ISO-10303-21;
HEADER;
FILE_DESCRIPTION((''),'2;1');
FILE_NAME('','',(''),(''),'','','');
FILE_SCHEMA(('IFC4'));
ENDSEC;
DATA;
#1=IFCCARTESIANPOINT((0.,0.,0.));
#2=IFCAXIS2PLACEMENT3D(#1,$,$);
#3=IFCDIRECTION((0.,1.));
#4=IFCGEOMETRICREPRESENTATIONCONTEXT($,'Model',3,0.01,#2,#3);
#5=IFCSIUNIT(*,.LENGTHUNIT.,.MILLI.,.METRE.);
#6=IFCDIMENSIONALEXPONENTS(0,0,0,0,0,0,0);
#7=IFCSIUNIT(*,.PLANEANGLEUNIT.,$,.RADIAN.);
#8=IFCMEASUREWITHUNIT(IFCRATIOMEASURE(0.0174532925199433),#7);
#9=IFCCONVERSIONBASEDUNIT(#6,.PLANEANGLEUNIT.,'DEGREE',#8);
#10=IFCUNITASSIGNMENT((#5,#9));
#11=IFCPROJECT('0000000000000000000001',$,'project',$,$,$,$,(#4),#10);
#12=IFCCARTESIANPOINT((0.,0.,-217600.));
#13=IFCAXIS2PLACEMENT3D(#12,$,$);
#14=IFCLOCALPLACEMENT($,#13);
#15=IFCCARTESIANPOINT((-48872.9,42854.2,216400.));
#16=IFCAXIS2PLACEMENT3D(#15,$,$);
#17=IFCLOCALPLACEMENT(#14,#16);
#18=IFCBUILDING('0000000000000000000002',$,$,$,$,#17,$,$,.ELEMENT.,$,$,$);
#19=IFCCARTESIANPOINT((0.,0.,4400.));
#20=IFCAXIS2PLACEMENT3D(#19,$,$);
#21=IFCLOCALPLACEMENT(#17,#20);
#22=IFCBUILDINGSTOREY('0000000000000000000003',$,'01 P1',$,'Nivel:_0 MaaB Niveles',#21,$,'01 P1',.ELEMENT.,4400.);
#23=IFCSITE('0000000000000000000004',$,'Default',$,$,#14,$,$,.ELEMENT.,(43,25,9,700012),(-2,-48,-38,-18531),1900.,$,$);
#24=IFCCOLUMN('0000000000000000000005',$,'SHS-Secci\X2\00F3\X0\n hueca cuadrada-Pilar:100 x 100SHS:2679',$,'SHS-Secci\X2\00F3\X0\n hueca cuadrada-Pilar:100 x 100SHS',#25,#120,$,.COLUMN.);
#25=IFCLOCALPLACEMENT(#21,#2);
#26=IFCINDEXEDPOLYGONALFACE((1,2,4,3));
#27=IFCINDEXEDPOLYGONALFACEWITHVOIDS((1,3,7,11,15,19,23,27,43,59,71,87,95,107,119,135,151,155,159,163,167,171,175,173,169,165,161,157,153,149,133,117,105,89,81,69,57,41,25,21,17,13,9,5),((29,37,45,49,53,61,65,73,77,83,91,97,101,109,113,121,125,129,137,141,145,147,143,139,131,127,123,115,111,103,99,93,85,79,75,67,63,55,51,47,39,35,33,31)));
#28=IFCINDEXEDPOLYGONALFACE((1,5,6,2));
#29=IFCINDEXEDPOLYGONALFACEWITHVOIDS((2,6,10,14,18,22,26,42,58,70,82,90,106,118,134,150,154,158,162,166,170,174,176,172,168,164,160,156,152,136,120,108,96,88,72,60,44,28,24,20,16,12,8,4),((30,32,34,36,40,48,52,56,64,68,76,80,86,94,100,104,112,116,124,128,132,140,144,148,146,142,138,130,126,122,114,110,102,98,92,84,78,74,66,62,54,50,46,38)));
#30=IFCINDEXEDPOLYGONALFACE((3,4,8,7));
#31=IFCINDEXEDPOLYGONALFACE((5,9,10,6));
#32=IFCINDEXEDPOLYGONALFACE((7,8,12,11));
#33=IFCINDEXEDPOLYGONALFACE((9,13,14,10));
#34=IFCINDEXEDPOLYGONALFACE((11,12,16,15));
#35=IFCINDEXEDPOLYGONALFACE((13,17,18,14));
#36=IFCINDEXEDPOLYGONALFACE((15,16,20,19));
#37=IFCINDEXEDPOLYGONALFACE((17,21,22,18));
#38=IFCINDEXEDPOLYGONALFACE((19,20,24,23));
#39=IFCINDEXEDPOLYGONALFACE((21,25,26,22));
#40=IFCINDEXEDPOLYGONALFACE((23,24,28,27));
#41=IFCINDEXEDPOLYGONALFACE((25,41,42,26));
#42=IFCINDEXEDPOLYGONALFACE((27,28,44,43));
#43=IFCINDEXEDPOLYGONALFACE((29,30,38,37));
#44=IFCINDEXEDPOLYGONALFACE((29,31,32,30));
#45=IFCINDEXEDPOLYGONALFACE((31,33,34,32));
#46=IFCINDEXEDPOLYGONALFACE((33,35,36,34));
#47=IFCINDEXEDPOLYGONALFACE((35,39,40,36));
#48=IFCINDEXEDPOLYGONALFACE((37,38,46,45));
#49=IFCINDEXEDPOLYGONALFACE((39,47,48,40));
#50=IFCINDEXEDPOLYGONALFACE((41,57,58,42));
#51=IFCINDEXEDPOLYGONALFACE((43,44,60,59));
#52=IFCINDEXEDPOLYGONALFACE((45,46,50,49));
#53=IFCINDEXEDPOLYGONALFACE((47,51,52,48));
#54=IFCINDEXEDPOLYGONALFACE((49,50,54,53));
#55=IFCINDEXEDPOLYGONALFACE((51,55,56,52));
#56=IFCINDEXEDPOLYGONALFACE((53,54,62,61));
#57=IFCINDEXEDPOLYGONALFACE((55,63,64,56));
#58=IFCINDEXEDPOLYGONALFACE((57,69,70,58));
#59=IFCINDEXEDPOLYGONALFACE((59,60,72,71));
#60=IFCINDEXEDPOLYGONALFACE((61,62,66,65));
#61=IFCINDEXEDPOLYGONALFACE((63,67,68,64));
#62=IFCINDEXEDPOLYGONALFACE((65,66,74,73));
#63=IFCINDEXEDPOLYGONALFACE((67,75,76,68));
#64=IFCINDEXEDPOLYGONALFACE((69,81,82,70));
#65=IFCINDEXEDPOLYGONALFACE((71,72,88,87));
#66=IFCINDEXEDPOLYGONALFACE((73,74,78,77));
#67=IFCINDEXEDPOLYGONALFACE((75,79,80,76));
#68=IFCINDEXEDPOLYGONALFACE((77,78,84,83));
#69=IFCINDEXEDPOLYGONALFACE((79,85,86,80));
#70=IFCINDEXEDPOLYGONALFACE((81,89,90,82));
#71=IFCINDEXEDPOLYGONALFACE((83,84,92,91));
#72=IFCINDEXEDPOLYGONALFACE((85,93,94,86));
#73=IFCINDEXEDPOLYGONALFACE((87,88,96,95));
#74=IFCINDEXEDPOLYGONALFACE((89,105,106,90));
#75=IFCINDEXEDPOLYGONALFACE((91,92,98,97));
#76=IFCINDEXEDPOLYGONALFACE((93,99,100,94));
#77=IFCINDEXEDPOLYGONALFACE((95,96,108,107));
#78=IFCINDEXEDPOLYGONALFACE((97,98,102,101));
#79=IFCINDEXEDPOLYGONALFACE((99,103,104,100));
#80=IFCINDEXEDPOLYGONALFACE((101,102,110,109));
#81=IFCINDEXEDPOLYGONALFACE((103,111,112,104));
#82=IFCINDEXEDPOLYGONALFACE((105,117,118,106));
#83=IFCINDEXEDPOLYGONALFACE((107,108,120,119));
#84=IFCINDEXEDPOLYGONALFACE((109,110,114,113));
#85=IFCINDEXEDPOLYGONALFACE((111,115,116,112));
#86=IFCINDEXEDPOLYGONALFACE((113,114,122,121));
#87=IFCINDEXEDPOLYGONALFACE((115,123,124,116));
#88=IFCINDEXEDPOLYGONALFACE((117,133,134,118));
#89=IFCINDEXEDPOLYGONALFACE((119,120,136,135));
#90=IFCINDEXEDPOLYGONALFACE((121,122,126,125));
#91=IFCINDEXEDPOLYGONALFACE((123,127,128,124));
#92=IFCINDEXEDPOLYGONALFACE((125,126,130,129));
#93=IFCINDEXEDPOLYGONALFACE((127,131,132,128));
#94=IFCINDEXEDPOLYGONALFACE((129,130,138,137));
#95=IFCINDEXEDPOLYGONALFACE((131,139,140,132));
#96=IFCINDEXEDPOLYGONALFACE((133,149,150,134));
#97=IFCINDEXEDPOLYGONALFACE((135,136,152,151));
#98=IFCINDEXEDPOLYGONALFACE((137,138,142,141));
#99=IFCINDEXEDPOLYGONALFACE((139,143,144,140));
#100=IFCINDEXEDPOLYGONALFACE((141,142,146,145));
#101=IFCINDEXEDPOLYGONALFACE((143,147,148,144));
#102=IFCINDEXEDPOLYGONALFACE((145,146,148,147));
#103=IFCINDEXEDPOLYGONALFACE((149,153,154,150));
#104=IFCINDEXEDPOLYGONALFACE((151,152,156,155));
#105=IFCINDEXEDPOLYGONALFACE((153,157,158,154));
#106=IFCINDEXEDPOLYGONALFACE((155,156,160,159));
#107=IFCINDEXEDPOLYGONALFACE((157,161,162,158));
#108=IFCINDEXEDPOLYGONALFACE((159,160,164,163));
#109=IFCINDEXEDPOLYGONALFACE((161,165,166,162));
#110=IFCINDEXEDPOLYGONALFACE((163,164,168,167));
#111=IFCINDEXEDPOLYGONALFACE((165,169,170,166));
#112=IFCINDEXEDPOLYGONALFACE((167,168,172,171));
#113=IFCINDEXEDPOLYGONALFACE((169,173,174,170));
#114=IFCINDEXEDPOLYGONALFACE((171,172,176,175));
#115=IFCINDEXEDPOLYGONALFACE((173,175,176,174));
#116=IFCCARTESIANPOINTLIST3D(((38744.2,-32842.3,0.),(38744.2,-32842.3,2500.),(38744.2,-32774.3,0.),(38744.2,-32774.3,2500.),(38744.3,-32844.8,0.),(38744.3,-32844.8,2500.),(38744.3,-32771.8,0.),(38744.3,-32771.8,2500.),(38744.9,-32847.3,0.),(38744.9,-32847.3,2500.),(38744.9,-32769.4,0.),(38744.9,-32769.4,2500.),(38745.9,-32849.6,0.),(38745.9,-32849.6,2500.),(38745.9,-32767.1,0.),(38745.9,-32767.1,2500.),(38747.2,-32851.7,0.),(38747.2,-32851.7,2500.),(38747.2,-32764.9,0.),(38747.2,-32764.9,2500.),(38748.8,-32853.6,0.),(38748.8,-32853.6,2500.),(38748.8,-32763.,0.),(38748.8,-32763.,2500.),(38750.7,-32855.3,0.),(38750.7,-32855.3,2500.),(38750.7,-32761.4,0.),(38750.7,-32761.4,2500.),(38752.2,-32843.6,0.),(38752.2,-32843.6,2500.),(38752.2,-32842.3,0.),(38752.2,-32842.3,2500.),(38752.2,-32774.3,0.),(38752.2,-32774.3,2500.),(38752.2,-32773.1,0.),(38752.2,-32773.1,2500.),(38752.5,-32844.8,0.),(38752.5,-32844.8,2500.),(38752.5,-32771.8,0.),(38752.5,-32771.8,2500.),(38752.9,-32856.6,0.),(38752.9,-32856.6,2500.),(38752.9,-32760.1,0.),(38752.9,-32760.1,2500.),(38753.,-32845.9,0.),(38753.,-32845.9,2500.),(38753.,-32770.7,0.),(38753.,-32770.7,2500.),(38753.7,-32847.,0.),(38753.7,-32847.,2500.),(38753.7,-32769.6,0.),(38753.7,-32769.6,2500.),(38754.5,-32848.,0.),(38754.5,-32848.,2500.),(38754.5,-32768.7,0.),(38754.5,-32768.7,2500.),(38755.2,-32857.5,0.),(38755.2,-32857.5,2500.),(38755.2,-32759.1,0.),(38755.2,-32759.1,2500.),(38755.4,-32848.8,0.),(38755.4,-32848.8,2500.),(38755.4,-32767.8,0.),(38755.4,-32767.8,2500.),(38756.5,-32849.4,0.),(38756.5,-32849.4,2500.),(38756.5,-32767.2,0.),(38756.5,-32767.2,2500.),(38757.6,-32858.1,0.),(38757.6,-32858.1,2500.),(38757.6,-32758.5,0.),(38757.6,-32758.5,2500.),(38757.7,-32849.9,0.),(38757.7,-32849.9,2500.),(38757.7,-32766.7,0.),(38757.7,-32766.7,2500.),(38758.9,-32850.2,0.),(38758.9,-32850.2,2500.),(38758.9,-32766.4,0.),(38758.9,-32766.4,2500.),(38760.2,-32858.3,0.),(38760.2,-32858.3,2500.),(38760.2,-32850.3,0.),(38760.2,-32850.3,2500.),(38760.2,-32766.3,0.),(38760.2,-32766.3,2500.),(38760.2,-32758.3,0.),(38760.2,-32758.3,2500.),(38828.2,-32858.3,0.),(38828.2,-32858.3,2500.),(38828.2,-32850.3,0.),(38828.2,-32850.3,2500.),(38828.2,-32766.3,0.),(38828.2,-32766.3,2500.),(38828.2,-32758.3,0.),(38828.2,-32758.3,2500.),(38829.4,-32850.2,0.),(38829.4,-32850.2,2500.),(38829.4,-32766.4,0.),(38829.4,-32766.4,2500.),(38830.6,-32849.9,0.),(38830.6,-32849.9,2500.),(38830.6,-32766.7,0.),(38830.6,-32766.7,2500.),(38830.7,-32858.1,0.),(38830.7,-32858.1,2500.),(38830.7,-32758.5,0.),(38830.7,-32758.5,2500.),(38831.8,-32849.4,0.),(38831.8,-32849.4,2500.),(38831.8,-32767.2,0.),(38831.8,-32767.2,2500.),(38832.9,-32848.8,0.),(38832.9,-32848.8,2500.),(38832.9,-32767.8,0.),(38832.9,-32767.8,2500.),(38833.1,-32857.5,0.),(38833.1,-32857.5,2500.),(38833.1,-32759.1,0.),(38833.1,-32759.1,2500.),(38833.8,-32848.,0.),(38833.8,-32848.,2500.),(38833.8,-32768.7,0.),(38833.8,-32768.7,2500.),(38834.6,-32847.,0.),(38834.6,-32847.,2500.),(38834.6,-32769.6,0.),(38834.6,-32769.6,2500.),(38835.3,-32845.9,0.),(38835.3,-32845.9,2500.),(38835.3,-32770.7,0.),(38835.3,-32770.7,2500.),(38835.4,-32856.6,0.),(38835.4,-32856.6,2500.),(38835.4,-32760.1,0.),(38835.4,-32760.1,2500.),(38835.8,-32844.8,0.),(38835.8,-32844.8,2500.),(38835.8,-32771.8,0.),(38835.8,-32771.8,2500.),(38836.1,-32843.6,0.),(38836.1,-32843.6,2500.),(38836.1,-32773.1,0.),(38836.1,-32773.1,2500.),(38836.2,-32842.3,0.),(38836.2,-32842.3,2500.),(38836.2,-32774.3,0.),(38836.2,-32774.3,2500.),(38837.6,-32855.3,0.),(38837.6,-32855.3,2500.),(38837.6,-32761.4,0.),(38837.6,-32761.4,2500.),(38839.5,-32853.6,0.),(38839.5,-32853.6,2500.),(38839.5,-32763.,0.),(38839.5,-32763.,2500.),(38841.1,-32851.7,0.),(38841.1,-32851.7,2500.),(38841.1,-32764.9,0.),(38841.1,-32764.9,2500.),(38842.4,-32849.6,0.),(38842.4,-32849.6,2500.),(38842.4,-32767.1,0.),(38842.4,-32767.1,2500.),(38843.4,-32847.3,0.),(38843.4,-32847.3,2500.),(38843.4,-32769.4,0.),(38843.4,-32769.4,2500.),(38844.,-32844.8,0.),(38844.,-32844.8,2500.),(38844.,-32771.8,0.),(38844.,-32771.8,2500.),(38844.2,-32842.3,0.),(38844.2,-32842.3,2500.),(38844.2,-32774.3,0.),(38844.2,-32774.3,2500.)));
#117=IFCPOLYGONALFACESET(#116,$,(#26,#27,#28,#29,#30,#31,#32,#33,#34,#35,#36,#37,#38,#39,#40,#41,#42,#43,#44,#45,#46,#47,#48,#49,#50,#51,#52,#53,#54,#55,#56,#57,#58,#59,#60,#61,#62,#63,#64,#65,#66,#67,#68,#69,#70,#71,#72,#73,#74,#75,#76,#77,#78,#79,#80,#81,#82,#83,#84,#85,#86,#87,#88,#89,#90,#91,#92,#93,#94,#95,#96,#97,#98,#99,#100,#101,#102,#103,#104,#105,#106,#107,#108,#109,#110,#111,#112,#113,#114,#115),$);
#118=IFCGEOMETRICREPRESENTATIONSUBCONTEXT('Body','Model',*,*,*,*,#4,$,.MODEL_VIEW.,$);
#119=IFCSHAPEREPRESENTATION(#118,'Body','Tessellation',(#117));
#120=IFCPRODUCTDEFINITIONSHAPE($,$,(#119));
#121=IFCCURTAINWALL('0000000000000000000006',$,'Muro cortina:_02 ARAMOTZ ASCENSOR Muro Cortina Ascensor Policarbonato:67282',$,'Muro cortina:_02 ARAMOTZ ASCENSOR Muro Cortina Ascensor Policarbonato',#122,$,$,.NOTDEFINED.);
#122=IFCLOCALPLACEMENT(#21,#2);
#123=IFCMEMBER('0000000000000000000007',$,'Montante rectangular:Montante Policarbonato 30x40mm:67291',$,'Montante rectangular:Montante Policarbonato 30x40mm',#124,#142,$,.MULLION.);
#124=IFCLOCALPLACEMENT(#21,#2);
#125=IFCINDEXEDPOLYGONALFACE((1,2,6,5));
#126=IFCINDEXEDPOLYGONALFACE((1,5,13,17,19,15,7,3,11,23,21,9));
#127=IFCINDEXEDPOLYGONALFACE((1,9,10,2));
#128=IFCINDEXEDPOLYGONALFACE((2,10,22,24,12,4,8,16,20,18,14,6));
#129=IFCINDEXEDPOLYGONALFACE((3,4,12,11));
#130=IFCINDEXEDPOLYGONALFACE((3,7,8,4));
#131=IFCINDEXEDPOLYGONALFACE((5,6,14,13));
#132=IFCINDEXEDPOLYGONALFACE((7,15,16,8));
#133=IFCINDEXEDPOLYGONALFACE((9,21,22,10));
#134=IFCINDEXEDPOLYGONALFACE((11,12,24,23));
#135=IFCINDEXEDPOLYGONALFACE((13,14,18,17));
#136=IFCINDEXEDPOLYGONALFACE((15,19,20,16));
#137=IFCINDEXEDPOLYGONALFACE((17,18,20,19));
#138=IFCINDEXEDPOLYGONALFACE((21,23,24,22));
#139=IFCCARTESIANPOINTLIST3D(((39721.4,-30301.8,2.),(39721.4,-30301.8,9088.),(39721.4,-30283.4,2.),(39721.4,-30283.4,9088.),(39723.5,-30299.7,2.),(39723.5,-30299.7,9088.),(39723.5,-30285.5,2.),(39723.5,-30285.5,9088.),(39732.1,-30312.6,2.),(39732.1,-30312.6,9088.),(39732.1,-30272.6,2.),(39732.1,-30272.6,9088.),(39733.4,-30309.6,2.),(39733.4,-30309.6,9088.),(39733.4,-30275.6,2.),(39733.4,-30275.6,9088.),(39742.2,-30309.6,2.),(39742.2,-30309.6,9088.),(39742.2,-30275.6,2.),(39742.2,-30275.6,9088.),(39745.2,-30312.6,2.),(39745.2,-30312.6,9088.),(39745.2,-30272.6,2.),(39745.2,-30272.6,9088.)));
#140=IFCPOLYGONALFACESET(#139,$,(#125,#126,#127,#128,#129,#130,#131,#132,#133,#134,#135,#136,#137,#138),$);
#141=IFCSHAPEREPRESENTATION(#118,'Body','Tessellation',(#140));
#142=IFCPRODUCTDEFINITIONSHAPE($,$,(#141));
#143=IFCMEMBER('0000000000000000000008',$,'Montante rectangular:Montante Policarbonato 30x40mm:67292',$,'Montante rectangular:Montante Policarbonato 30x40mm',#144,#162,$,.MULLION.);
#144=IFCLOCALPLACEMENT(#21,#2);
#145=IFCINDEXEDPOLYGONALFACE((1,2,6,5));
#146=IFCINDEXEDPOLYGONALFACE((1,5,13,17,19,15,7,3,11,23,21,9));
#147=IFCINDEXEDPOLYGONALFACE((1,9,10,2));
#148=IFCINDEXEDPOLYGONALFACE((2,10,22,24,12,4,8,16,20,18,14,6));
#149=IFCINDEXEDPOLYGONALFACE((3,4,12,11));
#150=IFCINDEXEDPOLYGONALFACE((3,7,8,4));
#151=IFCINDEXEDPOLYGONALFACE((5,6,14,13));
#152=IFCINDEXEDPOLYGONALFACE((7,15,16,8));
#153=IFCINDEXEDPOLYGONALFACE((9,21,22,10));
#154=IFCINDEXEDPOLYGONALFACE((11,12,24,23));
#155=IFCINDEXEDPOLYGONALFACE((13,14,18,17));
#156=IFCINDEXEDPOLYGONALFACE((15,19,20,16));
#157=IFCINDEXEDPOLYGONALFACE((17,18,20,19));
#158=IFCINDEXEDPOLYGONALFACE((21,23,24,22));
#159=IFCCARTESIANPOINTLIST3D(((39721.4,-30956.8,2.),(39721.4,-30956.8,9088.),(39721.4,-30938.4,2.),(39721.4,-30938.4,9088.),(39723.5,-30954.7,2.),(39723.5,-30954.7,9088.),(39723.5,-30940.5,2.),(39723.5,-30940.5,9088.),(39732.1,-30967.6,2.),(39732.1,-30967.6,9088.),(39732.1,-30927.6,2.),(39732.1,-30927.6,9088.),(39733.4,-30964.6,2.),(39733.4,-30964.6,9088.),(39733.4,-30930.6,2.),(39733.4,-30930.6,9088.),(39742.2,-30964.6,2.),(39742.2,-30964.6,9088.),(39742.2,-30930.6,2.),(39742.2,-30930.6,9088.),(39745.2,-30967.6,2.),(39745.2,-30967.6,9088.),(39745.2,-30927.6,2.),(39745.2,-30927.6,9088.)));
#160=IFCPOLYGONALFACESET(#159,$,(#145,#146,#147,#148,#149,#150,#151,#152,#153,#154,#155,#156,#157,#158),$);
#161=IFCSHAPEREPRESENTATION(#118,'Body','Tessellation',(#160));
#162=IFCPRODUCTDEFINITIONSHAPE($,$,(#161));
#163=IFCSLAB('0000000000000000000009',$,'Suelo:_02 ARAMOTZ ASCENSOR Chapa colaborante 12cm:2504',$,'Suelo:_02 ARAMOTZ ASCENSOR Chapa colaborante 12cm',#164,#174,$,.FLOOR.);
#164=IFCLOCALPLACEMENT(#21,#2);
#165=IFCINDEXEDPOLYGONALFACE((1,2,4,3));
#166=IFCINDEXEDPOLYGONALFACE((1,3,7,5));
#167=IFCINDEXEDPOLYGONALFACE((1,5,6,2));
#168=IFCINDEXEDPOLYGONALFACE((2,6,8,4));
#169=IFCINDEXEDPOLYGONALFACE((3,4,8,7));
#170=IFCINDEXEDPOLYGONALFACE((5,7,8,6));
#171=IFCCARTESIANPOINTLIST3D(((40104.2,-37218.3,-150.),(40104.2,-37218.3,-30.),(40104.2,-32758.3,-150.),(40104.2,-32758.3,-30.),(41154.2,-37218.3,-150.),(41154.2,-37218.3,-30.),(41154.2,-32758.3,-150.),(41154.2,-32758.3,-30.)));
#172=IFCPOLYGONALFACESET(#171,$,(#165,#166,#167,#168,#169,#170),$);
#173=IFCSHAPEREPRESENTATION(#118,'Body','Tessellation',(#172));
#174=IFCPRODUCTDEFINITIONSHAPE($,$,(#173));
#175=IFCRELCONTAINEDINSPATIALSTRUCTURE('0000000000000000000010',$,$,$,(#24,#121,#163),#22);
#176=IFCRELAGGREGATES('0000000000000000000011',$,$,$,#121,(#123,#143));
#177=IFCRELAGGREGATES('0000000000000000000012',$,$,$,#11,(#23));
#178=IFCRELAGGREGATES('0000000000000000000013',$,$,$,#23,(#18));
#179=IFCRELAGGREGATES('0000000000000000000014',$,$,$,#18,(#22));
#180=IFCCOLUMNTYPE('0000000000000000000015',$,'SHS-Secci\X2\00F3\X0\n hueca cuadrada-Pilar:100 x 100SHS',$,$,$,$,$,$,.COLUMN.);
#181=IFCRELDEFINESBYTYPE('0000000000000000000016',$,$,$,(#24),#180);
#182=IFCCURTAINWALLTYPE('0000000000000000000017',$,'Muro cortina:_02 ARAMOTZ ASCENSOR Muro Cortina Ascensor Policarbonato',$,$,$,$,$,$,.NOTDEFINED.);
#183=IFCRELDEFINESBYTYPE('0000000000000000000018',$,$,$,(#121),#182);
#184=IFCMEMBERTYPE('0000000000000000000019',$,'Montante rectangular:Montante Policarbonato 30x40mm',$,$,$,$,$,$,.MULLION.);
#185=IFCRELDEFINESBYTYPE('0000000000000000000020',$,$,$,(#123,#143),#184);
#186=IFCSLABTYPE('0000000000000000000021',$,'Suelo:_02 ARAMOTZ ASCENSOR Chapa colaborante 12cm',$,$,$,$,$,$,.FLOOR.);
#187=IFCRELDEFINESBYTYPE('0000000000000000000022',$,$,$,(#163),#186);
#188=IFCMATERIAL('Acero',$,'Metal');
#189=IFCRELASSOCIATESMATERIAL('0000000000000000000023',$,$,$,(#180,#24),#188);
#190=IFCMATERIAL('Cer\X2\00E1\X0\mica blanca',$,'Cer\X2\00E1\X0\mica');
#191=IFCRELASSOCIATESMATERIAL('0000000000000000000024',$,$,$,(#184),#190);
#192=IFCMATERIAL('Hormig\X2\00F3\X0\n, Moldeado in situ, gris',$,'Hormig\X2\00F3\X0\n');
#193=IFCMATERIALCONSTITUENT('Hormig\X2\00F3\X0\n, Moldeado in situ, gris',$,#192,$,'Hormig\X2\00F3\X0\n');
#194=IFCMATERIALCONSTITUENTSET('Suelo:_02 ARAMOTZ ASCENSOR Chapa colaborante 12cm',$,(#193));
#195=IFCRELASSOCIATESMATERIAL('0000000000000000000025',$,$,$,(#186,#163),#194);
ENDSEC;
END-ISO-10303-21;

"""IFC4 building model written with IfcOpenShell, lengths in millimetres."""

from ifc_helpers import new_model, entity, si_unit, converted_unit, direction, frame, origin, place, context, subcontext, project, spatial, indexed_curve, outline, extrude, source, transform, mapped, material, constituent, constituent_set, type_object, type_shapes, element, aggregate, save


model = new_model("IFC4")

# Units and contexts
model_context = context("Model", 3, precision=0.01, world=origin(), true_north=direction((0.0, 1.0)))
body_context = subcontext(model_context, "Body", "Model", "MODEL_VIEW")
ifc_project = project(units=[si_unit("LENGTHUNIT", "METRE", prefix="MILLI"), converted_unit("PLANEANGLEUNIT", "DEGREE", entity("IfcRatioMeasure", 0.0174532925199433), si_unit("PLANEANGLEUNIT", "RADIAN"), dimensions=[0, 0, 0, 0, 0, 0, 0])], contexts=[model_context])

# Site, building, storey
site_placement = place(None, frame((0.0, 0.0, -217600.0)))
site = spatial("IfcSite", under=ifc_project, at=site_placement, Name="Default", CompositionType="ELEMENT", RefLatitude=(43, 25, 9, 700012), RefLongitude=(-2, -48, -38, -18531), RefElevation=1900.0)
building_placement = place(site_placement, frame((-48872.9, 42854.2, 216400.0)))
building = spatial("IfcBuilding", under=site, at=building_placement, CompositionType="ELEMENT")
storey_placement = place(building_placement, frame((0.0, 0.0, 4400.0)))
storey = spatial("IfcBuildingStorey", under=building, at=storey_placement, Name="01 P1", ObjectType="Nivel:_0 MaaB Niveles", LongName="01 P1", CompositionType="ELEMENT", Elevation=4400.0)

# Column
ifc_material_1 = material(Name="Acero", Category="Metal")
column_type = type_object("IfcColumnType", Name="SHS-Sección hueca cuadrada-Pilar:100 x 100SHS", PredefinedType="COLUMN", material=ifc_material_1)
shared_shape_1 = source(origin(), body_context, "Body", "SweptSolid", [
    extrude(outline(indexed_curve([(-34.0, -50.0), (34.0, -50.0), (36.5, -49.8), (38.9, -49.2), (41.3, -48.3), (43.4, -46.9), (45.3, -45.3), (46.9, -43.4), (48.3, -41.3), (49.2, -38.9), (49.8, -36.5), (50.0, -34.0), (50.0, 34.0), (49.8, 36.5), (49.2, 38.9), (48.3, 41.3), (46.9, 43.4), (45.3, 45.3), (43.4, 46.9), (41.3, 48.3), (38.9, 49.2), (36.5, 49.8), (34.0, 50.0), (-34.0, 50.0), (-36.5, 49.8), (-38.9, 49.2), (-41.3, 48.3), (-43.4, 46.9), (-45.3, 45.3), (-46.9, 43.4), (-48.3, 41.3), (-49.2, 38.9), (-49.8, 36.5), (-50.0, 34.0), (-50.0, -34.0), (-49.8, -36.5), (-49.2, -38.9), (-48.3, -41.3), (-46.9, -43.4), (-45.3, -45.3), (-43.4, -46.9), (-41.3, -48.3), (-38.9, -49.2), (-36.5, -49.8), (-34.0, -50.0)], self_intersect=False), holes=[indexed_curve([(-42.0, 34.0), (-41.9, 35.3), (-41.6, 36.5), (-41.1, 37.6), (-40.5, 38.7), (-39.7, 39.7), (-38.7, 40.5), (-37.6, 41.1), (-36.5, 41.6), (-35.3, 41.9), (-34.0, 42.0), (34.0, 42.0), (35.3, 41.9), (36.5, 41.6), (37.6, 41.1), (38.7, 40.5), (39.7, 39.7), (40.5, 38.7), (41.1, 37.6), (41.6, 36.5), (41.9, 35.3), (42.0, 34.0), (42.0, -34.0), (41.9, -35.3), (41.6, -36.5), (41.1, -37.6), (40.5, -38.7), (39.7, -39.7), (38.7, -40.5), (37.6, -41.1), (36.5, -41.6), (35.3, -41.9), (34.0, -42.0), (-34.0, -42.0), (-35.3, -41.9), (-36.5, -41.6), (-37.6, -41.1), (-38.7, -40.5), (-39.7, -39.7), (-40.5, -38.7), (-41.1, -37.6), (-41.6, -36.5), (-41.9, -35.3), (-42.0, -34.0), (-42.0, 34.0)], self_intersect=False)]), frame((0.0, 0.0, 4400.0), z_axis=(0.0, 0.0, 1.0), x_axis=(0.0, 1.0, 0.0)), (0.0, 0.0, 1.0), 2500.0),
])
type_shapes(column_type, [shared_shape_1])
column_placement = place(storey_placement, frame((38794.2, -32808.3, -4400.0), z_axis=(0.0, 0.0, 1.0), x_axis=(0.0, -1.0, 0.0)))
element("IfcColumn", 1, at=column_placement, inside=storey, type_object=column_type, material=ifc_material_1, Name="SHS-Sección hueca cuadrada-Pilar:100 x 100SHS:2679", ObjectType="SHS-Sección hueca cuadrada-Pilar:100 x 100SHS", PredefinedType="COLUMN", context=body_context, shape_type="MappedRepresentation", body=[
    mapped(shared_shape_1, transform((0.0, 0.0, 0.0), scale=1.0)),
])

# Curtain wall, members
curtain_wall_type_1 = type_object("IfcCurtainWallType", Name="Muro cortina:_02 ARAMOTZ ASCENSOR Muro Cortina Ascensor Policarbonato", PredefinedType="NOTDEFINED")
curtain_wall_1_placement = place(storey_placement, frame((0.0, 0.0, -4400.0)))
curtain_wall_1 = element("IfcCurtainWall", 2, at=curtain_wall_1_placement, inside=storey, type_object=curtain_wall_type_1, Name="Muro cortina:_02 ARAMOTZ ASCENSOR Muro Cortina Ascensor Policarbonato:67282", ObjectType="Muro cortina:_02 ARAMOTZ ASCENSOR Muro Cortina Ascensor Policarbonato", PredefinedType="NOTDEFINED")
ifc_material_2 = material(Name="Cerámica blanca", Category="Cerámica")
member_type_1 = type_object("IfcMemberType", Name="Montante rectangular:Montante Policarbonato 30x40mm", PredefinedType="MULLION", material=ifc_material_2)
shared_shape_2 = source(origin(), body_context, "Body", "SweptSolid", [
    extrude(outline(indexed_curve([(-12.2, -20.0), (0.8, -20.0), (11.6, -9.2), (9.5, -7.1), (-0.4, -17.0), (-9.2, -17.0), (-9.2, 17.0), (-0.4, 17.0), (9.5, 7.1), (11.6, 9.2), (0.8, 20.0), (-12.2, 20.0), (-12.2, -20.0)], self_intersect=False)), frame((0.0, 29.1, -9086.0), z_axis=(0.0, 0.0, 1.0), x_axis=(0.0, -1.0, 0.0)), (0.0, 0.0, 1.0), 9086.0),
])
type_shapes(member_type_1, [shared_shape_2])
member_1_placement = place(curtain_wall_1_placement, frame((39703.9, -30292.6, 4402.0), z_axis=(0.0, 0.0, -1.0), x_axis=(0.0, 1.0, 0.0)))
member_1 = element("IfcMember", 3, at=member_1_placement, type_object=member_type_1, Name="Montante rectangular:Montante Policarbonato 30x40mm:67291", ObjectType="Montante rectangular:Montante Policarbonato 30x40mm", PredefinedType="MULLION", context=body_context, shape_type="MappedRepresentation", body=[
    mapped(shared_shape_2, transform((0.0, 0.0, 0.0), scale=1.0)),
])
member_2_placement = place(curtain_wall_1_placement, frame((39703.9, -30947.6, 4402.0), z_axis=(0.0, 0.0, -1.0), x_axis=(0.0, 1.0, 0.0)))
member_2 = element("IfcMember", 4, at=member_2_placement, type_object=member_type_1, Name="Montante rectangular:Montante Policarbonato 30x40mm:67292", ObjectType="Montante rectangular:Montante Policarbonato 30x40mm", PredefinedType="MULLION", context=body_context, shape_type="MappedRepresentation", body=[
    mapped(shared_shape_2, transform((0.0, 0.0, 0.0), scale=1.0)),
])

# Slab
ifc_material_3 = material(Name="Hormigón, Moldeado in situ, gris", Category="Hormigón")
ifc_constituent_1 = constituent(ifc_material_3, Name="Hormigón, Moldeado in situ, gris", Category="Hormigón")
ifc_constituent_set_1 = constituent_set(constituents=[ifc_constituent_1], Name="Suelo:_02 ARAMOTZ ASCENSOR Chapa colaborante 12cm")
slab_type_1 = type_object("IfcSlabType", Name="Suelo:_02 ARAMOTZ ASCENSOR Chapa colaborante 12cm", PredefinedType="FLOOR", material=ifc_constituent_set_1)
slab_1_placement = place(storey_placement, origin())
element("IfcSlab", 5, at=slab_1_placement, inside=storey, type_object=slab_type_1, material=ifc_constituent_set_1, Name="Suelo:_02 ARAMOTZ ASCENSOR Chapa colaborante 12cm:2504", ObjectType="Suelo:_02 ARAMOTZ ASCENSOR Chapa colaborante 12cm", PredefinedType="FLOOR", context=body_context, shape_type="SweptSolid", body=[
    extrude(outline(indexed_curve([(-525.0, -2230.0), (525.0, -2230.0), (525.0, 2230.0), (-525.0, 2230.0), (-525.0, -2230.0)], self_intersect=False)), frame((40629.2, -34988.3, -30.0), z_axis=(0.0, 0.0, -1.0), x_axis=(1.0, 0.0, 0.0)), (0.0, 0.0, 1.0), 120.0),
])

aggregate(curtain_wall_1, [member_1, member_2])

save(model, "model.ifc")
